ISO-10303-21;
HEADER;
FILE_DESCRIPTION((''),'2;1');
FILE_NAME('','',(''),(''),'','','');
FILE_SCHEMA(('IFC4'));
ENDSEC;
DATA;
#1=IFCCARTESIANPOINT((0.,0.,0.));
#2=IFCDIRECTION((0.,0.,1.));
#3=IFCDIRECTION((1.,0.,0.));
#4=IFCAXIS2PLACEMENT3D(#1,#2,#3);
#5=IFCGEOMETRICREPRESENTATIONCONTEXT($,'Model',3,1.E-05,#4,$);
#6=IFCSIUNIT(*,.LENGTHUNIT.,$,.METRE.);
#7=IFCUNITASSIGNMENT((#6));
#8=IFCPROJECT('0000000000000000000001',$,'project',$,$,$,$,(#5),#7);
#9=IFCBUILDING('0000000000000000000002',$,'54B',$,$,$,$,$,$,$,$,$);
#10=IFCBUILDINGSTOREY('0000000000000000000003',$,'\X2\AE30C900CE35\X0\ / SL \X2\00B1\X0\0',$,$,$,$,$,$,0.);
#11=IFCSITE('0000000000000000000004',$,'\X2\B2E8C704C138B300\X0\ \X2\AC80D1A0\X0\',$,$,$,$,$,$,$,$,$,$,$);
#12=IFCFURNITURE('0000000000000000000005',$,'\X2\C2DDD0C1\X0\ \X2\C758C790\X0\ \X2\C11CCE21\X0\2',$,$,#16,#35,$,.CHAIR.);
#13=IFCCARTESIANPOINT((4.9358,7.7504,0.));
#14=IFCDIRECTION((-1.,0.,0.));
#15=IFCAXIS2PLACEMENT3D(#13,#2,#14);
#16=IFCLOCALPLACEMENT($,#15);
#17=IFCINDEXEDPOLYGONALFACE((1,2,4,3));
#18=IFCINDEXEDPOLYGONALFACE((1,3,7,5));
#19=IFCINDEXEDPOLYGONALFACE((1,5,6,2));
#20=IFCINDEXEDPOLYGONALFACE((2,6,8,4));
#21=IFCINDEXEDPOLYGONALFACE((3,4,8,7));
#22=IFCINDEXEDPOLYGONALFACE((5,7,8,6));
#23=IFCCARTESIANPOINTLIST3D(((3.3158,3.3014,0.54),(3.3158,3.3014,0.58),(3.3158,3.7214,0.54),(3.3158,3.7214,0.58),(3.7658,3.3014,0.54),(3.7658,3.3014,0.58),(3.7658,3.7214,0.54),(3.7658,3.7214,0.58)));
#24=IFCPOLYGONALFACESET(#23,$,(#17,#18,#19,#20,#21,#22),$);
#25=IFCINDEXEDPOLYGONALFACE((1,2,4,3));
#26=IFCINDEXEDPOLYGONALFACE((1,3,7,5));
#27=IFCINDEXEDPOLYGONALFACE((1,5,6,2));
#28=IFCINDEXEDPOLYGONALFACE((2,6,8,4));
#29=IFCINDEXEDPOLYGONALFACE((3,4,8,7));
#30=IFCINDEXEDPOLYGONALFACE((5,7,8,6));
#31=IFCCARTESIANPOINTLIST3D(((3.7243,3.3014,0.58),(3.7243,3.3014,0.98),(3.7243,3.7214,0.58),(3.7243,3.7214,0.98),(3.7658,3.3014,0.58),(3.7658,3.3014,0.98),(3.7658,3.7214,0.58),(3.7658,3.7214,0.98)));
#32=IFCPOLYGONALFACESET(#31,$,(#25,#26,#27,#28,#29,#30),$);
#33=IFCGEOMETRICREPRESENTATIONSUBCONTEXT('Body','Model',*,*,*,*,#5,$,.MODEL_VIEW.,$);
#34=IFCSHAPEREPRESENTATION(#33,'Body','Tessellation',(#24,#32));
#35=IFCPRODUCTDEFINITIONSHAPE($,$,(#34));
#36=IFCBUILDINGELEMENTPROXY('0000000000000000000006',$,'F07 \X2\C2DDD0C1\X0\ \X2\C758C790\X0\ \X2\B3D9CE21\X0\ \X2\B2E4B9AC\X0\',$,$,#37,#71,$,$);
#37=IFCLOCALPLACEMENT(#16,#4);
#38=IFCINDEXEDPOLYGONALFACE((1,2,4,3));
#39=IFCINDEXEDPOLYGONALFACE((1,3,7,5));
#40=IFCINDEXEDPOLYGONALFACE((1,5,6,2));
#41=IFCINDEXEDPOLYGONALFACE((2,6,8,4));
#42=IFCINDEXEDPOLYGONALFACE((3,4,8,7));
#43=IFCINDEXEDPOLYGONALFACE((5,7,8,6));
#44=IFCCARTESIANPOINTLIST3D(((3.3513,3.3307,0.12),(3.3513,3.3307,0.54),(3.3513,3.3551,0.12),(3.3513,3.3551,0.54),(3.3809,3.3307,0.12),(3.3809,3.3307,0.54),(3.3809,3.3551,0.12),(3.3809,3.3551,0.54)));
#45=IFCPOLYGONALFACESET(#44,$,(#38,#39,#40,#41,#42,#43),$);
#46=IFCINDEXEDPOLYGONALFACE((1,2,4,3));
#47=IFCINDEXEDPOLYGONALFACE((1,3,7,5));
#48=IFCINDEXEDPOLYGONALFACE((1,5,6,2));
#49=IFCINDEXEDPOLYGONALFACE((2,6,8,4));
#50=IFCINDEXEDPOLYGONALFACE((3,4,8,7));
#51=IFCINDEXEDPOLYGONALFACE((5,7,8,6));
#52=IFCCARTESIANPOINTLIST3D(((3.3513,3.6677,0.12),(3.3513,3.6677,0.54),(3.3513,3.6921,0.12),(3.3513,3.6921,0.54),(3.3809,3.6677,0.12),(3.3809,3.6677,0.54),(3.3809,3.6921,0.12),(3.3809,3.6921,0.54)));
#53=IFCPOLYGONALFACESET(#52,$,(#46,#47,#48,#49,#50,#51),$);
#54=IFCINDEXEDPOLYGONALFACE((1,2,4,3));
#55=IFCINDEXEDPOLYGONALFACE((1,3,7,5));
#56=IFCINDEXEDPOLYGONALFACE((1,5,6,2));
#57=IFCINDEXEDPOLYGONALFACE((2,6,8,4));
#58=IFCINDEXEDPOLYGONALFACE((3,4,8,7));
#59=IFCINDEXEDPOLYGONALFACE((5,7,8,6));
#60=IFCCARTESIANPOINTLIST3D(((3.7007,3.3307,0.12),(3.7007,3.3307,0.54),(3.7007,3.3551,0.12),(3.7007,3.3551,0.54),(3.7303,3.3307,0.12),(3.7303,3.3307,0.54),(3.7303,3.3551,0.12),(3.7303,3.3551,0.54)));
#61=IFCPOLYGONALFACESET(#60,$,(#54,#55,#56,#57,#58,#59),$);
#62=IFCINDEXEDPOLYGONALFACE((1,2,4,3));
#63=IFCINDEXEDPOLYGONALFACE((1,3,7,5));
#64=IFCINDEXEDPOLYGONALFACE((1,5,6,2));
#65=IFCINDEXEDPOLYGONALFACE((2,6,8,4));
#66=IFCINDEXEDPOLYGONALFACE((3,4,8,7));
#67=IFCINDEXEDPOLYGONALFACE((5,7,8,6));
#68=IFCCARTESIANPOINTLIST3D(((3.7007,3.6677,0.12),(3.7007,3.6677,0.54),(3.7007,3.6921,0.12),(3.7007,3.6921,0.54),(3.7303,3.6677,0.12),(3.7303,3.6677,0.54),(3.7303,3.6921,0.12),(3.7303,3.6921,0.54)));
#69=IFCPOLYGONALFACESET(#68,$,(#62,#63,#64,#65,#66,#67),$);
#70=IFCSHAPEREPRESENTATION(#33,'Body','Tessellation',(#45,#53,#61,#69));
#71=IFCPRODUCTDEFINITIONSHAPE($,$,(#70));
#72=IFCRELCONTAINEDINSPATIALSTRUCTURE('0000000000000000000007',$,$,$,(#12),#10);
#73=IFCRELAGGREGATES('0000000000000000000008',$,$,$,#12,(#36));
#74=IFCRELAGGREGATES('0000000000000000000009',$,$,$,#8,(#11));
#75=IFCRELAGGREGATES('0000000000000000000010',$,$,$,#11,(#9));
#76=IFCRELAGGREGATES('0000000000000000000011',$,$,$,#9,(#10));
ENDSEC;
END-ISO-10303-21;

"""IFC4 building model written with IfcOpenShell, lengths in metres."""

from ifc_helpers import new_model, si_unit, frame, origin_with_axes, place, context, subcontext, project, spatial, polyline, outline, extrude, element, aggregate, save


model = new_model("IFC4")

# Units and contexts
model_context = context("Model", 3, precision=1e-05, world=origin_with_axes())
body_context = subcontext(model_context, "Body", "Model", "MODEL_VIEW")
ifc_project = project(units=[si_unit("LENGTHUNIT", "METRE")], contexts=[model_context])

# Site, building, storey
site = spatial("IfcSite", under=ifc_project, Name="단위세대 검토")
building = spatial("IfcBuilding", under=site, Name="54B")
storey = spatial("IfcBuildingStorey", under=building, Name="기준층 / SL ±0", Elevation=0.0)

# Furniture
furniture_1_placement = place(None, frame((4.9358, 7.7504, 0.0), z_axis=(0.0, 0.0, 1.0), x_axis=(-1.0, 0.0, 0.0)))
furniture_1 = element("IfcFurniture", 1, at=furniture_1_placement, inside=storey, Name="식탁 의자 서측2", PredefinedType="CHAIR", context=body_context, shape_type="SweptSolid", body=[
    extrude(outline(polyline([(3.7658, 3.3014), (3.7658, 3.7214), (3.3158, 3.7214), (3.3158, 3.3014), (3.7658, 3.3014)])), frame((0.0, 0.0, 0.54)), (0.0, 0.0, 1.0), 0.04),
    extrude(outline(polyline([(3.7658, 3.3014), (3.7658, 3.7214), (3.7243, 3.7214), (3.7243, 3.3014), (3.7658, 3.3014)])), frame((0.0, 0.0, 0.58)), (0.0, 0.0, 1.0), 0.4),
])

# Building element proxy
proxy_1_placement = place(furniture_1_placement, origin_with_axes())
proxy_1 = element("IfcBuildingElementProxy", 2, at=proxy_1_placement, Name="F07 식탁 의자 동측 다리", context=body_context, shape_type="SweptSolid", body=[
    extrude(outline(polyline([(3.3809, 3.3307), (3.3809, 3.3551), (3.3513, 3.3551), (3.3513, 3.3307), (3.3809, 3.3307)])), frame((0.0, 0.0, 0.12)), (0.0, 0.0, 1.0), 0.42),
    extrude(outline(polyline([(3.3809, 3.6677), (3.3809, 3.6921), (3.3513, 3.6921), (3.3513, 3.6677), (3.3809, 3.6677)])), frame((0.0, 0.0, 0.12)), (0.0, 0.0, 1.0), 0.42),
    extrude(outline(polyline([(3.7303, 3.3307), (3.7303, 3.3551), (3.7007, 3.3551), (3.7007, 3.3307), (3.7303, 3.3307)])), frame((0.0, 0.0, 0.12)), (0.0, 0.0, 1.0), 0.42),
    extrude(outline(polyline([(3.7303, 3.6677), (3.7303, 3.6921), (3.7007, 3.6921), (3.7007, 3.6677), (3.7303, 3.6677)])), frame((0.0, 0.0, 0.12)), (0.0, 0.0, 1.0), 0.42),
])
aggregate(furniture_1, [proxy_1])

save(model, "model.ifc")
